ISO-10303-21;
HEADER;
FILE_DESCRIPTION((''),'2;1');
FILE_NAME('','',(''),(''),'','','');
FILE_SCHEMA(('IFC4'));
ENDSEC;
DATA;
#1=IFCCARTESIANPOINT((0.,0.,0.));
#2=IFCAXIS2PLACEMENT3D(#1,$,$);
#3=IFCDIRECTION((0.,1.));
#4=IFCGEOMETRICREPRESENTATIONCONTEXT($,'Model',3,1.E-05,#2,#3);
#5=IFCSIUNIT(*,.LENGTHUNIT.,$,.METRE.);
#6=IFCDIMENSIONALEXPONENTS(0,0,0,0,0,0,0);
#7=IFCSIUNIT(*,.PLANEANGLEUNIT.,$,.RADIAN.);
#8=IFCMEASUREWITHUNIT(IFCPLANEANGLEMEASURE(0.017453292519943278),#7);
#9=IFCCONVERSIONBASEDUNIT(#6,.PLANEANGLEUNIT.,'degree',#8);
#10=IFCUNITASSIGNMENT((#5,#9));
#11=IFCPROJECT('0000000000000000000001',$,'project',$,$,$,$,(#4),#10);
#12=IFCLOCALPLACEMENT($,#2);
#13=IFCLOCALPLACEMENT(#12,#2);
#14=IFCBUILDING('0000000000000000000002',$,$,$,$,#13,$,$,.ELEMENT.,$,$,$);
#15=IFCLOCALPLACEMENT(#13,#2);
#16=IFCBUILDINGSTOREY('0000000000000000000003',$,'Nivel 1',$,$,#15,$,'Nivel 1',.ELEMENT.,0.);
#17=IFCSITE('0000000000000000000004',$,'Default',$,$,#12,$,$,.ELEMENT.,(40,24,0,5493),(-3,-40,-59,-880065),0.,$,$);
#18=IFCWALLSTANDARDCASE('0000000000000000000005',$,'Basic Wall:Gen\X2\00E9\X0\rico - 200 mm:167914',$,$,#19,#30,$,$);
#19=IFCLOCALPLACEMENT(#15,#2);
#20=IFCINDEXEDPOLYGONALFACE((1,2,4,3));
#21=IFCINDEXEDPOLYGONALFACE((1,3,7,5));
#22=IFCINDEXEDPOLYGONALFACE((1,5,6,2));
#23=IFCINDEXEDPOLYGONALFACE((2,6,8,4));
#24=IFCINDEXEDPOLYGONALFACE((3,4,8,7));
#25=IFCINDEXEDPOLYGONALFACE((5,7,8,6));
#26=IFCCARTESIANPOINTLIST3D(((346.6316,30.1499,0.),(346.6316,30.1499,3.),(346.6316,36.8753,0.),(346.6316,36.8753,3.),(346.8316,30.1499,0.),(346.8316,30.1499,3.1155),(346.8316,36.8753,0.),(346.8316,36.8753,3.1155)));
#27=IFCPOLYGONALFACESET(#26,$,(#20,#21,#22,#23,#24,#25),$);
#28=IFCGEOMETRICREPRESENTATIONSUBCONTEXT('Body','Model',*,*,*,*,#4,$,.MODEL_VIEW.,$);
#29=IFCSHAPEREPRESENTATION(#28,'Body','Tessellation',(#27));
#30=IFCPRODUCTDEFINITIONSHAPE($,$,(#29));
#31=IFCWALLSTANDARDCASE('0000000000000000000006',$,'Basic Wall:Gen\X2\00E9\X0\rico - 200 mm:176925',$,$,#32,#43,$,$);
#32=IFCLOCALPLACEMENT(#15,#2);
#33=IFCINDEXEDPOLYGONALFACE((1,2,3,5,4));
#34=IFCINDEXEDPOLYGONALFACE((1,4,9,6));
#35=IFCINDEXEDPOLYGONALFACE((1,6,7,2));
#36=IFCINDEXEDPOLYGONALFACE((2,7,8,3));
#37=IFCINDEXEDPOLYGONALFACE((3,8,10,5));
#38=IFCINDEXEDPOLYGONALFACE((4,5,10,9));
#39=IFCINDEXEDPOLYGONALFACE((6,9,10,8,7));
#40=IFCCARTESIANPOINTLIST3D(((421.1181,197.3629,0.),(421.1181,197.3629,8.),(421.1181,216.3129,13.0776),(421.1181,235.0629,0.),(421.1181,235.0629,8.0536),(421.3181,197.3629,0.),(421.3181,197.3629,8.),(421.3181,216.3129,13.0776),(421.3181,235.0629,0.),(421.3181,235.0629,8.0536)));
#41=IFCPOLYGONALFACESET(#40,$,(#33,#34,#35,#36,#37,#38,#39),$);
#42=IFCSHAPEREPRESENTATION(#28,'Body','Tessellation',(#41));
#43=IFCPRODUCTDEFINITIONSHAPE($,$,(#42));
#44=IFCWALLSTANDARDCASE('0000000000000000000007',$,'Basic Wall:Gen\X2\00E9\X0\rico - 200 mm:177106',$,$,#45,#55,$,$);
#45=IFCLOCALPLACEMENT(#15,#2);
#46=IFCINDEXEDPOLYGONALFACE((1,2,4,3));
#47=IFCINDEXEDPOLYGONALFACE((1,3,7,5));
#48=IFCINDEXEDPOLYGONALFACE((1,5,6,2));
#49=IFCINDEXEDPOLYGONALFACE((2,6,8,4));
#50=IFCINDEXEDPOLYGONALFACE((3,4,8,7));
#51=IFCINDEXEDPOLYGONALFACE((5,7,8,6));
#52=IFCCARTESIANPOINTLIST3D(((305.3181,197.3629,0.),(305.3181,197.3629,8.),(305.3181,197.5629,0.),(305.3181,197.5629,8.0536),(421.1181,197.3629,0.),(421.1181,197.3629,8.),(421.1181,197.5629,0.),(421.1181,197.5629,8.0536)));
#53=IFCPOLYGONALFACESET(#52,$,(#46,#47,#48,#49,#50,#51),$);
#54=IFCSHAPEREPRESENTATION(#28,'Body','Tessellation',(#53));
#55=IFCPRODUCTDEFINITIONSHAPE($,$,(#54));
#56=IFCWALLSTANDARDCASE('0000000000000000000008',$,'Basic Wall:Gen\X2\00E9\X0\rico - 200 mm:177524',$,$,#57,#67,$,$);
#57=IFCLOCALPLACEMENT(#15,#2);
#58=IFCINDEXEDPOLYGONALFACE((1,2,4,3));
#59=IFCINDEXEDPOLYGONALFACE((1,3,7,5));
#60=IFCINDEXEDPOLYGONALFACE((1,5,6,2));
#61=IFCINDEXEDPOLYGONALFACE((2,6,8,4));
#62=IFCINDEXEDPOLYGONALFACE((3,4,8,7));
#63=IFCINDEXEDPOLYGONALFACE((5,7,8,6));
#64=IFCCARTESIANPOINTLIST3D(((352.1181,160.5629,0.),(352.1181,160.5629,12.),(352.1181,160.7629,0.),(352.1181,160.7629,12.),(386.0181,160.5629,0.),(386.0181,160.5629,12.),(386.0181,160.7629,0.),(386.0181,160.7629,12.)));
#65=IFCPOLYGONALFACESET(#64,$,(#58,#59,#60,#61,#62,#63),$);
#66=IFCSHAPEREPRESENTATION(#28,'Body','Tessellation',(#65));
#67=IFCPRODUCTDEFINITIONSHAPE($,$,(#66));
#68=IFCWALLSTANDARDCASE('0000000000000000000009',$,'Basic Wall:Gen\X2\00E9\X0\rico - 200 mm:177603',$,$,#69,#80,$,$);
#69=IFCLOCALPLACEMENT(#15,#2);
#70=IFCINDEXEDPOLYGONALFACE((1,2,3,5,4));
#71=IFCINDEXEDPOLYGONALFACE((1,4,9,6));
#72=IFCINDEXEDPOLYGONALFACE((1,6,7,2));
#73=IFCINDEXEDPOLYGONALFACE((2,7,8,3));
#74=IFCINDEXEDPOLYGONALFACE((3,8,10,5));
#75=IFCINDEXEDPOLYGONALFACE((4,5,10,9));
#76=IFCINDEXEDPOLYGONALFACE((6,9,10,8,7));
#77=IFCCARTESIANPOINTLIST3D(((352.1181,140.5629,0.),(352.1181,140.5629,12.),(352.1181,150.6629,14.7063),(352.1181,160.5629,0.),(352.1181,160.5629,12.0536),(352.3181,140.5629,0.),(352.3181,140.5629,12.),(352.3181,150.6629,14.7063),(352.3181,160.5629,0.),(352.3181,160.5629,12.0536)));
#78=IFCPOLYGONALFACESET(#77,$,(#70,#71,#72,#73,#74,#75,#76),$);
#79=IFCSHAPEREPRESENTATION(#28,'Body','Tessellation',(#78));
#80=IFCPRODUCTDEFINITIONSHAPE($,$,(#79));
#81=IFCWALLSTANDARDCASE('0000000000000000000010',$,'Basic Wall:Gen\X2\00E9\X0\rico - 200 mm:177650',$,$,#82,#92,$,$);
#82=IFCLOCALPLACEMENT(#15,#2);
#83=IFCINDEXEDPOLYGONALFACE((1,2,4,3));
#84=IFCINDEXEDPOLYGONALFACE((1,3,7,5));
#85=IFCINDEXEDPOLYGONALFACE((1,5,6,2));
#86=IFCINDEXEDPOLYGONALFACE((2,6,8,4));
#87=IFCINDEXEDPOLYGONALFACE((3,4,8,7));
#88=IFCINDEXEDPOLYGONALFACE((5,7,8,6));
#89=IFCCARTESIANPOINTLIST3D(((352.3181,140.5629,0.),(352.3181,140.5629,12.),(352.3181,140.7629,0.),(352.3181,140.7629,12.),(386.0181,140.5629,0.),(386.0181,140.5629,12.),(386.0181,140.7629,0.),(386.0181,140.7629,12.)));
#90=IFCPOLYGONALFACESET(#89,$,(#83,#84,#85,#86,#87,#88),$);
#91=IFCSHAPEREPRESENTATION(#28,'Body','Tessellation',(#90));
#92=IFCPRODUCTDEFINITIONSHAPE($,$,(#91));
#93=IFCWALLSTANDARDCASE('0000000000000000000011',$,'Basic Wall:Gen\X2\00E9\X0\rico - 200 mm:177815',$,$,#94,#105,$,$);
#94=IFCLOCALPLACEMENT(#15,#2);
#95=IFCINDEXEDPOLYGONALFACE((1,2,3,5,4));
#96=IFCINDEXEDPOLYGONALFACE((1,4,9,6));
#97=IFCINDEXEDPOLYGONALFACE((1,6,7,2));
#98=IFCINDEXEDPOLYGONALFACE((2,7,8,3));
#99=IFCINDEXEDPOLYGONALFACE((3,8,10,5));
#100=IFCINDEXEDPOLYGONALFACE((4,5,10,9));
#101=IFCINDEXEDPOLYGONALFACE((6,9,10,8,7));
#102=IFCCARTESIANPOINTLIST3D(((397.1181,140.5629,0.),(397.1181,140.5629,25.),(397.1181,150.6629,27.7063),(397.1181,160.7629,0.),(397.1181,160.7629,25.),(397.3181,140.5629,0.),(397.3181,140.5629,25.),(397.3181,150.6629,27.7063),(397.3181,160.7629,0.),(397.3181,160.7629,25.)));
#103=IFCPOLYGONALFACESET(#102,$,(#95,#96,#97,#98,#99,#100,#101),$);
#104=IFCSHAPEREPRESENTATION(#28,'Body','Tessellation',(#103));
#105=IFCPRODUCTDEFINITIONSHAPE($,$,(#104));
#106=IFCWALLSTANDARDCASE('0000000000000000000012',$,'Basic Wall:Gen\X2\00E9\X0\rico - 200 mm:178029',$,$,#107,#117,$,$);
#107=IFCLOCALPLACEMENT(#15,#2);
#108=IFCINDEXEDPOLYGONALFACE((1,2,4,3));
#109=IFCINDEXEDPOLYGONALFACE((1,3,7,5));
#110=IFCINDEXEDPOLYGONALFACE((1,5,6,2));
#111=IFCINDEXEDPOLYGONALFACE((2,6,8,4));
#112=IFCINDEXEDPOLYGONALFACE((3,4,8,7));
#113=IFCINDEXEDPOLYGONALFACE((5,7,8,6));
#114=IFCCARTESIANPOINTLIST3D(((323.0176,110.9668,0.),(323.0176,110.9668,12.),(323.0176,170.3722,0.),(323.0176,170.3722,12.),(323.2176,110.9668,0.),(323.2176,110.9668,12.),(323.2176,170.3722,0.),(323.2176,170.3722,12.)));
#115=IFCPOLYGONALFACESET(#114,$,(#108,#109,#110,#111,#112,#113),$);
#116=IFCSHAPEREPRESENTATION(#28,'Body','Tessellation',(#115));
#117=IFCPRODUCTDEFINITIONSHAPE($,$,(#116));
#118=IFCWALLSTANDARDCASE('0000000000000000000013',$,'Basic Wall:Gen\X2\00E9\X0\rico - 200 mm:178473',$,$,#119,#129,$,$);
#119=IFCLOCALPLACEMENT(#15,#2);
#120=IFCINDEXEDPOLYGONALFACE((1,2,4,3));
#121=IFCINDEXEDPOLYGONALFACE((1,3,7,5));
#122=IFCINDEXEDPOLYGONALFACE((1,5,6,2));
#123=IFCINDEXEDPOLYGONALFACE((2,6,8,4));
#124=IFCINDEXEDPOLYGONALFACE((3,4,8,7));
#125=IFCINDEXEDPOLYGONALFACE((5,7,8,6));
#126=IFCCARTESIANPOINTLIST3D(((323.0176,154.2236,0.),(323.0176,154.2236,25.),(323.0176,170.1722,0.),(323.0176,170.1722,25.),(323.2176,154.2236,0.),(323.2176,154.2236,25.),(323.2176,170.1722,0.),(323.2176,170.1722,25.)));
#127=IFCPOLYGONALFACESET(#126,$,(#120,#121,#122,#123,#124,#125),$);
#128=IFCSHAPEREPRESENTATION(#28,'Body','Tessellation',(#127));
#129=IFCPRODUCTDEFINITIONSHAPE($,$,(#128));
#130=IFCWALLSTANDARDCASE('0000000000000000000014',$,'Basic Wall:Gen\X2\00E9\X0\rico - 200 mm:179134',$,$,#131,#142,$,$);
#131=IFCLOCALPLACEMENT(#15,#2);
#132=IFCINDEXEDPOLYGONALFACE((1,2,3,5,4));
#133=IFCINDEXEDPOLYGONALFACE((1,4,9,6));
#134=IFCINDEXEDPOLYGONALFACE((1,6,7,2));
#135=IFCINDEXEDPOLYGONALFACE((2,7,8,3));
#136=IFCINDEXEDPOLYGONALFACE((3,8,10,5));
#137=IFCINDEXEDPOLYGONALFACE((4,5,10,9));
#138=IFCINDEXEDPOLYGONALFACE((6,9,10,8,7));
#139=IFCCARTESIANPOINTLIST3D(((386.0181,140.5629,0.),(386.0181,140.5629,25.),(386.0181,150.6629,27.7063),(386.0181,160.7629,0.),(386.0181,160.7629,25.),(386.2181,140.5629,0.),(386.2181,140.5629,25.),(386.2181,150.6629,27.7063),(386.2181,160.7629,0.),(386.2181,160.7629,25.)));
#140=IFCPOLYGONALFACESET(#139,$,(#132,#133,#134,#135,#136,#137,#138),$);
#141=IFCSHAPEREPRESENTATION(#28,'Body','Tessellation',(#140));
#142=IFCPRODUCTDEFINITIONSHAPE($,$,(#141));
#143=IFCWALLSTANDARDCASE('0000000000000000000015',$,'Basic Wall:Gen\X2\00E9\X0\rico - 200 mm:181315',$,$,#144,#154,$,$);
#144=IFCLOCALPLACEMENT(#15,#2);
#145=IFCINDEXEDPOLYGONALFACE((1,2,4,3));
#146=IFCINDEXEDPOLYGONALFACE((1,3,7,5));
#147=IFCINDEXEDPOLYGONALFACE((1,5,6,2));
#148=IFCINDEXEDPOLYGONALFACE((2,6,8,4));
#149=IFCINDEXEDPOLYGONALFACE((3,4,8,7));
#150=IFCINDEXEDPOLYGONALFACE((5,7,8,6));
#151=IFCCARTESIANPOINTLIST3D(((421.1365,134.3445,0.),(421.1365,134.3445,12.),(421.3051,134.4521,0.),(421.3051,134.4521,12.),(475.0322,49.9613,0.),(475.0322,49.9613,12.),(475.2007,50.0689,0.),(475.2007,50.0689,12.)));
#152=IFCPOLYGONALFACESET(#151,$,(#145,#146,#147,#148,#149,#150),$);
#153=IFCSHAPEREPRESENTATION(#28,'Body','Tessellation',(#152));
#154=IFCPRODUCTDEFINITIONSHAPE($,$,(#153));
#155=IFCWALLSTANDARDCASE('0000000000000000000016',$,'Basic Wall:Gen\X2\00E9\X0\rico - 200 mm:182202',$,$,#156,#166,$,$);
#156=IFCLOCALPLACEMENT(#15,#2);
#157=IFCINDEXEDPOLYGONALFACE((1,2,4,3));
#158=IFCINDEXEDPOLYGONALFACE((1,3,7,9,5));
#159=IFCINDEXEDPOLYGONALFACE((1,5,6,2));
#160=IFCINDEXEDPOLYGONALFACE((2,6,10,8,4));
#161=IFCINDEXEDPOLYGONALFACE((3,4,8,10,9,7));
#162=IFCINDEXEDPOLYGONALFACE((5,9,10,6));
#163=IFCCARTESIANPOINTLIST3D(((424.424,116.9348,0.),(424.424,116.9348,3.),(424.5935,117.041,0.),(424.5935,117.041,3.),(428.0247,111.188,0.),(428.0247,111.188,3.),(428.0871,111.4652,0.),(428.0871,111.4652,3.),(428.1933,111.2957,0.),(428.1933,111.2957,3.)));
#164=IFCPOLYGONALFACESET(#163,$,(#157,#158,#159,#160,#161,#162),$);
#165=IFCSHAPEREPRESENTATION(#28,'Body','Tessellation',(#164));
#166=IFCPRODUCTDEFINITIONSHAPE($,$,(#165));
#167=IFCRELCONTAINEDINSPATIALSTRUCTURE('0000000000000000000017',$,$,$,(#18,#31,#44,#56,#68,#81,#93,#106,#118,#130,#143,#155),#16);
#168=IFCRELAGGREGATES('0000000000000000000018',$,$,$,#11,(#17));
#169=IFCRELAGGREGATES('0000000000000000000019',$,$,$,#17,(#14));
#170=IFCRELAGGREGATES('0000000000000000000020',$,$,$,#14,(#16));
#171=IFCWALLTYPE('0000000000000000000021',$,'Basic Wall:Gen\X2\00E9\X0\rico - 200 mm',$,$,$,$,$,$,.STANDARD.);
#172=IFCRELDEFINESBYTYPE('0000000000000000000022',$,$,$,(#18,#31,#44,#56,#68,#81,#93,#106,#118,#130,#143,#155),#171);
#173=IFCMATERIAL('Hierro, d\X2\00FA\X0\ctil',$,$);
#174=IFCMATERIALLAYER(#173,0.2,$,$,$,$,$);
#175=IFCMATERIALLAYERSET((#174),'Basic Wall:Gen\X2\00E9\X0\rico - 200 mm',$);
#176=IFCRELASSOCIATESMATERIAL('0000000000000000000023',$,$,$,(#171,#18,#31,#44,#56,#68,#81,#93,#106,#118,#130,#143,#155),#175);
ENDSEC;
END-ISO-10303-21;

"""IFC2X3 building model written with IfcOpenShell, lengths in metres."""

from ifc_helpers import new_model, entity, si_unit, converted_unit, direction, frame, frame_2d, origin, place, context, subcontext, project, spatial, polyline, rectangle, outline, extrude, clip, bounded_halfspace, material, layer, layer_set, layer_usage, type_object, element, save


model = new_model("IFC2X3")

# Units and contexts
model_context = context("Model", 3, precision=1e-05, world=origin(), true_north=direction((0.0, 1.0)))
body_context = subcontext(model_context, "Body", "Model", "MODEL_VIEW")
ifc_project = project(units=[si_unit("LENGTHUNIT", "METRE"), converted_unit("PLANEANGLEUNIT", "degree", entity("IfcPlaneAngleMeasure", 0.017453292519943278), si_unit("PLANEANGLEUNIT", "RADIAN"), dimensions=[0, 0, 0, 0, 0, 0, 0])], contexts=[model_context])

# Site, building, storey
site_placement = place(None, origin())
site = spatial("IfcSite", under=ifc_project, at=site_placement, Name="Default", CompositionType="ELEMENT", RefLatitude=(40, 24, 0, 5493), RefLongitude=(-3, -40, -59, -880065), RefElevation=0.0)
building_placement = place(site_placement, origin())
building = spatial("IfcBuilding", under=site, at=building_placement, CompositionType="ELEMENT")
storey_placement = place(building_placement, origin())
storey = spatial("IfcBuildingStorey", under=building, at=storey_placement, Name="Nivel 1", LongName="Nivel 1", CompositionType="ELEMENT", Elevation=0.0)

# Shared definitions
ifc_material = material(Name="Hierro, dúctil")
ifc_layer = layer(ifc_material, 0.2)
ifc_layer_set = layer_set([ifc_layer], Name="Basic Wall:Genérico - 200 mm")
wall_type = type_object("IfcWallType", Name="Basic Wall:Genérico - 200 mm", PredefinedType="STANDARD", material=ifc_layer_set)

# Walls
ifc_layer_usage_1 = layer_usage(ifc_layer_set, "AXIS2", "NEGATIVE", 0.1)
wall_1_placement = place(storey_placement, frame((346.7316, 30.1499, 0.0), z_axis=(0.0, 0.0, 1.0), x_axis=(0.0, 1.0, 0.0)))
element("IfcWallStandardCase", 1, at=wall_1_placement, inside=storey, type_object=wall_type, material=ifc_layer_usage_1, Name="Basic Wall:Genérico - 200 mm:167914", context=body_context, shape_type="Clipping", body=[
    clip(extrude(rectangle(XDim=6.7253, YDim=0.2, at=frame_2d((3.3627, 0.0), x_axis=(-1.0, 0.0))), origin(), (0.0, 0.0, 1.0), 3.1155), bounded_halfspace(frame((0.0, -0.1, 3.1155), z_axis=(0.0, 0.5, 0.866025), x_axis=(-1.0, 0.0, 0.0)), False, frame((0.0, -0.1, 3.1155)), polyline([(0.0, 0.0), (6.7253, 0.0), (6.7253, 0.2), (0.0, 0.2), (0.0, 0.0)]))),
])
ifc_layer_usage_2 = layer_usage(ifc_layer_set, "AXIS2", "NEGATIVE", 0.1)
wall_2_placement = place(storey_placement, frame((421.2181, 235.0629, 0.0), z_axis=(0.0, 0.0, 1.0), x_axis=(0.0, -1.0, 0.0)))
element("IfcWallStandardCase", 2, at=wall_2_placement, inside=storey, type_object=wall_type, material=ifc_layer_usage_2, Name="Basic Wall:Genérico - 200 mm:176925", context=body_context, shape_type="Clipping", body=[
    clip(clip(extrude(rectangle(XDim=37.7, YDim=0.2, at=frame_2d((18.85, 0.0), x_axis=(-1.0, 0.0))), origin(), (0.0, 0.0, 1.0), 13.0776), bounded_halfspace(frame((0.0, -0.1, 8.0536), z_axis=(-0.258819, 0.0, 0.965926), x_axis=(0.0, -1.0, 0.0)), False, frame((0.0, -0.1, 8.0536)), polyline([(0.0, 0.0), (18.75, 0.0), (18.75, 0.2), (0.0, 0.2), (0.0, 0.0)]))), bounded_halfspace(frame((18.75, -0.1, 13.0776), z_axis=(0.258819, 0.0, 0.965926), x_axis=(0.0, 1.0, 0.0)), False, frame((18.75, -0.1, 13.0776)), polyline([(0.0, 0.0), (18.75, 0.0), (18.95, 0.0), (18.95, 0.2), (0.0, 0.2), (0.0, 0.0)]))),
])
ifc_layer_usage_3 = layer_usage(ifc_layer_set, "AXIS2", "NEGATIVE", 0.1)
wall_3_placement = place(storey_placement, frame((421.1181, 197.4629, 0.0), z_axis=(0.0, 0.0, 1.0), x_axis=(-1.0, 0.0, 0.0)))
element("IfcWallStandardCase", 3, at=wall_3_placement, inside=storey, type_object=wall_type, material=ifc_layer_usage_3, Name="Basic Wall:Genérico - 200 mm:177106", context=body_context, shape_type="Clipping", body=[
    clip(extrude(rectangle(XDim=115.8, YDim=0.2, at=frame_2d((57.9, 0.0), x_axis=(-1.0, 0.0))), origin(), (0.0, 0.0, 1.0), 8.0536), bounded_halfspace(frame((0.0, -0.1, 8.0536), z_axis=(0.0, 0.258819, 0.965926), x_axis=(-1.0, 0.0, 0.0)), False, frame((0.0, -0.1, 8.0536)), polyline([(0.0, 0.0), (115.6, 0.0), (115.8, 0.0), (115.8, 0.2), (0.0, 0.2), (0.0, 0.0)]))),
])
ifc_layer_usage_4 = layer_usage(ifc_layer_set, "AXIS2", "NEGATIVE", 0.1)
wall_4_placement = place(storey_placement, frame((352.1181, 160.6629, 0.0)))
element("IfcWallStandardCase", 4, at=wall_4_placement, inside=storey, type_object=wall_type, material=ifc_layer_usage_4, Name="Basic Wall:Genérico - 200 mm:177524", context=body_context, shape_type="SweptSolid", body=[
    extrude(rectangle(XDim=33.9, YDim=0.2, at=frame_2d((16.95, 0.0), x_axis=(-1.0, 0.0))), origin(), (0.0, 0.0, 1.0), 12.0),
])
ifc_layer_usage_5 = layer_usage(ifc_layer_set, "AXIS2", "NEGATIVE", 0.1)
wall_5_placement = place(storey_placement, frame((352.2181, 160.5629, 0.0), z_axis=(0.0, 0.0, 1.0), x_axis=(0.0, -1.0, 0.0)))
element("IfcWallStandardCase", 5, at=wall_5_placement, inside=storey, type_object=wall_type, material=ifc_layer_usage_5, Name="Basic Wall:Genérico - 200 mm:177603", context=body_context, shape_type="Clipping", body=[
    clip(clip(extrude(rectangle(XDim=20.0, YDim=0.2, at=frame_2d((10.0, 0.0), x_axis=(-1.0, 0.0))), origin(), (0.0, 0.0, 1.0), 14.7063), bounded_halfspace(frame((0.0, -0.1, 12.0536), z_axis=(-0.258819, 0.0, 0.965926), x_axis=(0.0, -1.0, 0.0)), False, frame((0.0, -0.1, 12.0536)), polyline([(0.0, 0.0), (9.9, 0.0), (9.9, 0.2), (0.0, 0.2), (0.0, 0.0)]))), bounded_halfspace(frame((9.9, -0.1, 14.7063), z_axis=(0.258819, 0.0, 0.965926), x_axis=(0.0, 1.0, 0.0)), False, frame((9.9, -0.1, 14.7063)), polyline([(0.0, 0.0), (10.1, 0.0), (10.1, 0.2), (0.0, 0.2), (0.0, 0.0)]))),
])
ifc_layer_usage_6 = layer_usage(ifc_layer_set, "AXIS2", "NEGATIVE", 0.1)
wall_6_placement = place(storey_placement, frame((352.3181, 140.6629, 0.0)))
element("IfcWallStandardCase", 6, at=wall_6_placement, inside=storey, type_object=wall_type, material=ifc_layer_usage_6, Name="Basic Wall:Genérico - 200 mm:177650", context=body_context, shape_type="SweptSolid", body=[
    extrude(rectangle(XDim=33.7, YDim=0.2, at=frame_2d((16.85, 0.0), x_axis=(-1.0, 0.0))), origin(), (0.0, 0.0, 1.0), 12.0),
])
ifc_layer_usage_7 = layer_usage(ifc_layer_set, "AXIS2", "NEGATIVE", 0.1)
wall_7_placement = place(storey_placement, frame((397.2181, 140.5629, 0.0), z_axis=(0.0, 0.0, 1.0), x_axis=(0.0, 1.0, 0.0)))
element("IfcWallStandardCase", 7, at=wall_7_placement, inside=storey, type_object=wall_type, material=ifc_layer_usage_7, Name="Basic Wall:Genérico - 200 mm:177815", context=body_context, shape_type="Clipping", body=[
    clip(clip(extrude(rectangle(XDim=20.2, YDim=0.2, at=frame_2d((10.1, 0.0), x_axis=(-1.0, 0.0))), origin(), (0.0, 0.0, 1.0), 27.7063), bounded_halfspace(frame((10.1, -0.1, 27.7063), z_axis=(0.258819, 0.0, 0.965926), x_axis=(0.0, 1.0, 0.0)), False, frame((10.1, -0.1, 27.7063)), polyline([(0.0, 0.0), (10.1, 0.0), (10.1, 0.2), (9.9, 0.2), (0.0, 0.2), (0.0, 0.0)]))), bounded_halfspace(frame((0.0, -0.1, 25.0), z_axis=(-0.258819, 0.0, 0.965926), x_axis=(0.0, -1.0, 0.0)), False, frame((0.0, -0.1, 25.0)), polyline([(0.0, 0.0), (10.1, 0.0), (10.1, 0.2), (0.2, 0.2), (0.0, 0.2), (0.0, 0.0)]))),
])
ifc_layer_usage_8 = layer_usage(ifc_layer_set, "AXIS2", "NEGATIVE", 0.1)
wall_8_placement = place(storey_placement, frame((323.1176, 110.9668, 0.0), z_axis=(0.0, 0.0, 1.0), x_axis=(0.0, 1.0, 0.0)))
element("IfcWallStandardCase", 8, at=wall_8_placement, inside=storey, type_object=wall_type, material=ifc_layer_usage_8, Name="Basic Wall:Genérico - 200 mm:178029", context=body_context, shape_type="SweptSolid", body=[
    extrude(rectangle(XDim=59.4055, YDim=0.2, at=frame_2d((29.7027, 0.0), x_axis=(-1.0, 0.0))), origin(), (0.0, 0.0, 1.0), 12.0),
])
ifc_layer_usage_9 = layer_usage(ifc_layer_set, "AXIS2", "NEGATIVE", 0.1)
wall_9_placement = place(storey_placement, frame((323.1176, 154.2236, 0.0), z_axis=(0.0, 0.0, 1.0), x_axis=(0.0, 1.0, 0.0)))
element("IfcWallStandardCase", 9, at=wall_9_placement, inside=storey, type_object=wall_type, material=ifc_layer_usage_9, Name="Basic Wall:Genérico - 200 mm:178473", context=body_context, shape_type="SweptSolid", body=[
    extrude(rectangle(XDim=15.9486, YDim=0.2, at=frame_2d((7.9743, 0.0), x_axis=(-1.0, 0.0))), origin(), (0.0, 0.0, 1.0), 25.0),
])
ifc_layer_usage_10 = layer_usage(ifc_layer_set, "AXIS2", "POSITIVE", -0.1)
wall_10_placement = place(storey_placement, frame((386.1181, 140.5629, 0.0), z_axis=(0.0, 0.0, 1.0), x_axis=(0.0, 1.0, 0.0)))
element("IfcWallStandardCase", 10, at=wall_10_placement, inside=storey, type_object=wall_type, material=ifc_layer_usage_10, Name="Basic Wall:Genérico - 200 mm:179134", context=body_context, shape_type="Clipping", body=[
    clip(clip(extrude(rectangle(XDim=20.2, YDim=0.2, at=frame_2d((10.1, 0.0), x_axis=(-1.0, 0.0))), origin(), (0.0, 0.0, 1.0), 27.7063), bounded_halfspace(frame((10.1, -0.1, 27.7063), z_axis=(0.258819, 0.0, 0.965926), x_axis=(0.0, 1.0, 0.0)), False, frame((10.1, -0.1, 27.7063)), polyline([(0.0, 0.0), (9.9, 0.0), (10.1, 0.0), (10.1, 0.2), (0.0, 0.2), (0.0, 0.0)]))), bounded_halfspace(frame((0.0, -0.1, 25.0), z_axis=(-0.258819, 0.0, 0.965926), x_axis=(0.0, -1.0, 0.0)), False, frame((0.0, -0.1, 25.0)), polyline([(0.0, 0.0), (0.2, 0.0), (10.1, 0.0), (10.1, 0.2), (0.0, 0.2), (0.0, 0.0)]))),
])
ifc_layer_usage_11 = layer_usage(ifc_layer_set, "AXIS2", "NEGATIVE", 0.1)
wall_11_placement = place(storey_placement, frame((421.2208, 134.3983, 0.0), z_axis=(0.0, 0.0, 1.0), x_axis=(0.538277, -0.842768, 0.0)))
element("IfcWallStandardCase", 11, at=wall_11_placement, inside=storey, type_object=wall_type, material=ifc_layer_usage_11, Name="Basic Wall:Genérico - 200 mm:181315", context=body_context, shape_type="SweptSolid", body=[
    extrude(rectangle(XDim=100.1262, YDim=0.2, at=frame_2d((50.0631, 0.0), x_axis=(-1.0, 0.0))), origin(), (0.0, 0.0, 1.0), 12.0),
])
ifc_layer_usage_12 = layer_usage(ifc_layer_set, "AXIS2", "NEGATIVE", 0.1)
wall_12_placement = place(storey_placement, frame((424.5088, 116.9879, 0.0), z_axis=(0.0, 0.0, 1.0), x_axis=(0.530951, -0.847403, 0.0)))
element("IfcWallStandardCase", 12, at=wall_12_placement, inside=storey, type_object=wall_type, material=ifc_layer_usage_12, Name="Basic Wall:Genérico - 200 mm:182202", context=body_context, shape_type="SweptSolid", body=[
    extrude(outline(polyline([(6.7816, -0.1), (6.7799, 0.1), (6.5799, 0.1), (0.0, 0.1), (0.0, -0.1), (6.7816, -0.1)])), origin(), (0.0, 0.0, 1.0), 3.0),
])

save(model, "model.ifc")
